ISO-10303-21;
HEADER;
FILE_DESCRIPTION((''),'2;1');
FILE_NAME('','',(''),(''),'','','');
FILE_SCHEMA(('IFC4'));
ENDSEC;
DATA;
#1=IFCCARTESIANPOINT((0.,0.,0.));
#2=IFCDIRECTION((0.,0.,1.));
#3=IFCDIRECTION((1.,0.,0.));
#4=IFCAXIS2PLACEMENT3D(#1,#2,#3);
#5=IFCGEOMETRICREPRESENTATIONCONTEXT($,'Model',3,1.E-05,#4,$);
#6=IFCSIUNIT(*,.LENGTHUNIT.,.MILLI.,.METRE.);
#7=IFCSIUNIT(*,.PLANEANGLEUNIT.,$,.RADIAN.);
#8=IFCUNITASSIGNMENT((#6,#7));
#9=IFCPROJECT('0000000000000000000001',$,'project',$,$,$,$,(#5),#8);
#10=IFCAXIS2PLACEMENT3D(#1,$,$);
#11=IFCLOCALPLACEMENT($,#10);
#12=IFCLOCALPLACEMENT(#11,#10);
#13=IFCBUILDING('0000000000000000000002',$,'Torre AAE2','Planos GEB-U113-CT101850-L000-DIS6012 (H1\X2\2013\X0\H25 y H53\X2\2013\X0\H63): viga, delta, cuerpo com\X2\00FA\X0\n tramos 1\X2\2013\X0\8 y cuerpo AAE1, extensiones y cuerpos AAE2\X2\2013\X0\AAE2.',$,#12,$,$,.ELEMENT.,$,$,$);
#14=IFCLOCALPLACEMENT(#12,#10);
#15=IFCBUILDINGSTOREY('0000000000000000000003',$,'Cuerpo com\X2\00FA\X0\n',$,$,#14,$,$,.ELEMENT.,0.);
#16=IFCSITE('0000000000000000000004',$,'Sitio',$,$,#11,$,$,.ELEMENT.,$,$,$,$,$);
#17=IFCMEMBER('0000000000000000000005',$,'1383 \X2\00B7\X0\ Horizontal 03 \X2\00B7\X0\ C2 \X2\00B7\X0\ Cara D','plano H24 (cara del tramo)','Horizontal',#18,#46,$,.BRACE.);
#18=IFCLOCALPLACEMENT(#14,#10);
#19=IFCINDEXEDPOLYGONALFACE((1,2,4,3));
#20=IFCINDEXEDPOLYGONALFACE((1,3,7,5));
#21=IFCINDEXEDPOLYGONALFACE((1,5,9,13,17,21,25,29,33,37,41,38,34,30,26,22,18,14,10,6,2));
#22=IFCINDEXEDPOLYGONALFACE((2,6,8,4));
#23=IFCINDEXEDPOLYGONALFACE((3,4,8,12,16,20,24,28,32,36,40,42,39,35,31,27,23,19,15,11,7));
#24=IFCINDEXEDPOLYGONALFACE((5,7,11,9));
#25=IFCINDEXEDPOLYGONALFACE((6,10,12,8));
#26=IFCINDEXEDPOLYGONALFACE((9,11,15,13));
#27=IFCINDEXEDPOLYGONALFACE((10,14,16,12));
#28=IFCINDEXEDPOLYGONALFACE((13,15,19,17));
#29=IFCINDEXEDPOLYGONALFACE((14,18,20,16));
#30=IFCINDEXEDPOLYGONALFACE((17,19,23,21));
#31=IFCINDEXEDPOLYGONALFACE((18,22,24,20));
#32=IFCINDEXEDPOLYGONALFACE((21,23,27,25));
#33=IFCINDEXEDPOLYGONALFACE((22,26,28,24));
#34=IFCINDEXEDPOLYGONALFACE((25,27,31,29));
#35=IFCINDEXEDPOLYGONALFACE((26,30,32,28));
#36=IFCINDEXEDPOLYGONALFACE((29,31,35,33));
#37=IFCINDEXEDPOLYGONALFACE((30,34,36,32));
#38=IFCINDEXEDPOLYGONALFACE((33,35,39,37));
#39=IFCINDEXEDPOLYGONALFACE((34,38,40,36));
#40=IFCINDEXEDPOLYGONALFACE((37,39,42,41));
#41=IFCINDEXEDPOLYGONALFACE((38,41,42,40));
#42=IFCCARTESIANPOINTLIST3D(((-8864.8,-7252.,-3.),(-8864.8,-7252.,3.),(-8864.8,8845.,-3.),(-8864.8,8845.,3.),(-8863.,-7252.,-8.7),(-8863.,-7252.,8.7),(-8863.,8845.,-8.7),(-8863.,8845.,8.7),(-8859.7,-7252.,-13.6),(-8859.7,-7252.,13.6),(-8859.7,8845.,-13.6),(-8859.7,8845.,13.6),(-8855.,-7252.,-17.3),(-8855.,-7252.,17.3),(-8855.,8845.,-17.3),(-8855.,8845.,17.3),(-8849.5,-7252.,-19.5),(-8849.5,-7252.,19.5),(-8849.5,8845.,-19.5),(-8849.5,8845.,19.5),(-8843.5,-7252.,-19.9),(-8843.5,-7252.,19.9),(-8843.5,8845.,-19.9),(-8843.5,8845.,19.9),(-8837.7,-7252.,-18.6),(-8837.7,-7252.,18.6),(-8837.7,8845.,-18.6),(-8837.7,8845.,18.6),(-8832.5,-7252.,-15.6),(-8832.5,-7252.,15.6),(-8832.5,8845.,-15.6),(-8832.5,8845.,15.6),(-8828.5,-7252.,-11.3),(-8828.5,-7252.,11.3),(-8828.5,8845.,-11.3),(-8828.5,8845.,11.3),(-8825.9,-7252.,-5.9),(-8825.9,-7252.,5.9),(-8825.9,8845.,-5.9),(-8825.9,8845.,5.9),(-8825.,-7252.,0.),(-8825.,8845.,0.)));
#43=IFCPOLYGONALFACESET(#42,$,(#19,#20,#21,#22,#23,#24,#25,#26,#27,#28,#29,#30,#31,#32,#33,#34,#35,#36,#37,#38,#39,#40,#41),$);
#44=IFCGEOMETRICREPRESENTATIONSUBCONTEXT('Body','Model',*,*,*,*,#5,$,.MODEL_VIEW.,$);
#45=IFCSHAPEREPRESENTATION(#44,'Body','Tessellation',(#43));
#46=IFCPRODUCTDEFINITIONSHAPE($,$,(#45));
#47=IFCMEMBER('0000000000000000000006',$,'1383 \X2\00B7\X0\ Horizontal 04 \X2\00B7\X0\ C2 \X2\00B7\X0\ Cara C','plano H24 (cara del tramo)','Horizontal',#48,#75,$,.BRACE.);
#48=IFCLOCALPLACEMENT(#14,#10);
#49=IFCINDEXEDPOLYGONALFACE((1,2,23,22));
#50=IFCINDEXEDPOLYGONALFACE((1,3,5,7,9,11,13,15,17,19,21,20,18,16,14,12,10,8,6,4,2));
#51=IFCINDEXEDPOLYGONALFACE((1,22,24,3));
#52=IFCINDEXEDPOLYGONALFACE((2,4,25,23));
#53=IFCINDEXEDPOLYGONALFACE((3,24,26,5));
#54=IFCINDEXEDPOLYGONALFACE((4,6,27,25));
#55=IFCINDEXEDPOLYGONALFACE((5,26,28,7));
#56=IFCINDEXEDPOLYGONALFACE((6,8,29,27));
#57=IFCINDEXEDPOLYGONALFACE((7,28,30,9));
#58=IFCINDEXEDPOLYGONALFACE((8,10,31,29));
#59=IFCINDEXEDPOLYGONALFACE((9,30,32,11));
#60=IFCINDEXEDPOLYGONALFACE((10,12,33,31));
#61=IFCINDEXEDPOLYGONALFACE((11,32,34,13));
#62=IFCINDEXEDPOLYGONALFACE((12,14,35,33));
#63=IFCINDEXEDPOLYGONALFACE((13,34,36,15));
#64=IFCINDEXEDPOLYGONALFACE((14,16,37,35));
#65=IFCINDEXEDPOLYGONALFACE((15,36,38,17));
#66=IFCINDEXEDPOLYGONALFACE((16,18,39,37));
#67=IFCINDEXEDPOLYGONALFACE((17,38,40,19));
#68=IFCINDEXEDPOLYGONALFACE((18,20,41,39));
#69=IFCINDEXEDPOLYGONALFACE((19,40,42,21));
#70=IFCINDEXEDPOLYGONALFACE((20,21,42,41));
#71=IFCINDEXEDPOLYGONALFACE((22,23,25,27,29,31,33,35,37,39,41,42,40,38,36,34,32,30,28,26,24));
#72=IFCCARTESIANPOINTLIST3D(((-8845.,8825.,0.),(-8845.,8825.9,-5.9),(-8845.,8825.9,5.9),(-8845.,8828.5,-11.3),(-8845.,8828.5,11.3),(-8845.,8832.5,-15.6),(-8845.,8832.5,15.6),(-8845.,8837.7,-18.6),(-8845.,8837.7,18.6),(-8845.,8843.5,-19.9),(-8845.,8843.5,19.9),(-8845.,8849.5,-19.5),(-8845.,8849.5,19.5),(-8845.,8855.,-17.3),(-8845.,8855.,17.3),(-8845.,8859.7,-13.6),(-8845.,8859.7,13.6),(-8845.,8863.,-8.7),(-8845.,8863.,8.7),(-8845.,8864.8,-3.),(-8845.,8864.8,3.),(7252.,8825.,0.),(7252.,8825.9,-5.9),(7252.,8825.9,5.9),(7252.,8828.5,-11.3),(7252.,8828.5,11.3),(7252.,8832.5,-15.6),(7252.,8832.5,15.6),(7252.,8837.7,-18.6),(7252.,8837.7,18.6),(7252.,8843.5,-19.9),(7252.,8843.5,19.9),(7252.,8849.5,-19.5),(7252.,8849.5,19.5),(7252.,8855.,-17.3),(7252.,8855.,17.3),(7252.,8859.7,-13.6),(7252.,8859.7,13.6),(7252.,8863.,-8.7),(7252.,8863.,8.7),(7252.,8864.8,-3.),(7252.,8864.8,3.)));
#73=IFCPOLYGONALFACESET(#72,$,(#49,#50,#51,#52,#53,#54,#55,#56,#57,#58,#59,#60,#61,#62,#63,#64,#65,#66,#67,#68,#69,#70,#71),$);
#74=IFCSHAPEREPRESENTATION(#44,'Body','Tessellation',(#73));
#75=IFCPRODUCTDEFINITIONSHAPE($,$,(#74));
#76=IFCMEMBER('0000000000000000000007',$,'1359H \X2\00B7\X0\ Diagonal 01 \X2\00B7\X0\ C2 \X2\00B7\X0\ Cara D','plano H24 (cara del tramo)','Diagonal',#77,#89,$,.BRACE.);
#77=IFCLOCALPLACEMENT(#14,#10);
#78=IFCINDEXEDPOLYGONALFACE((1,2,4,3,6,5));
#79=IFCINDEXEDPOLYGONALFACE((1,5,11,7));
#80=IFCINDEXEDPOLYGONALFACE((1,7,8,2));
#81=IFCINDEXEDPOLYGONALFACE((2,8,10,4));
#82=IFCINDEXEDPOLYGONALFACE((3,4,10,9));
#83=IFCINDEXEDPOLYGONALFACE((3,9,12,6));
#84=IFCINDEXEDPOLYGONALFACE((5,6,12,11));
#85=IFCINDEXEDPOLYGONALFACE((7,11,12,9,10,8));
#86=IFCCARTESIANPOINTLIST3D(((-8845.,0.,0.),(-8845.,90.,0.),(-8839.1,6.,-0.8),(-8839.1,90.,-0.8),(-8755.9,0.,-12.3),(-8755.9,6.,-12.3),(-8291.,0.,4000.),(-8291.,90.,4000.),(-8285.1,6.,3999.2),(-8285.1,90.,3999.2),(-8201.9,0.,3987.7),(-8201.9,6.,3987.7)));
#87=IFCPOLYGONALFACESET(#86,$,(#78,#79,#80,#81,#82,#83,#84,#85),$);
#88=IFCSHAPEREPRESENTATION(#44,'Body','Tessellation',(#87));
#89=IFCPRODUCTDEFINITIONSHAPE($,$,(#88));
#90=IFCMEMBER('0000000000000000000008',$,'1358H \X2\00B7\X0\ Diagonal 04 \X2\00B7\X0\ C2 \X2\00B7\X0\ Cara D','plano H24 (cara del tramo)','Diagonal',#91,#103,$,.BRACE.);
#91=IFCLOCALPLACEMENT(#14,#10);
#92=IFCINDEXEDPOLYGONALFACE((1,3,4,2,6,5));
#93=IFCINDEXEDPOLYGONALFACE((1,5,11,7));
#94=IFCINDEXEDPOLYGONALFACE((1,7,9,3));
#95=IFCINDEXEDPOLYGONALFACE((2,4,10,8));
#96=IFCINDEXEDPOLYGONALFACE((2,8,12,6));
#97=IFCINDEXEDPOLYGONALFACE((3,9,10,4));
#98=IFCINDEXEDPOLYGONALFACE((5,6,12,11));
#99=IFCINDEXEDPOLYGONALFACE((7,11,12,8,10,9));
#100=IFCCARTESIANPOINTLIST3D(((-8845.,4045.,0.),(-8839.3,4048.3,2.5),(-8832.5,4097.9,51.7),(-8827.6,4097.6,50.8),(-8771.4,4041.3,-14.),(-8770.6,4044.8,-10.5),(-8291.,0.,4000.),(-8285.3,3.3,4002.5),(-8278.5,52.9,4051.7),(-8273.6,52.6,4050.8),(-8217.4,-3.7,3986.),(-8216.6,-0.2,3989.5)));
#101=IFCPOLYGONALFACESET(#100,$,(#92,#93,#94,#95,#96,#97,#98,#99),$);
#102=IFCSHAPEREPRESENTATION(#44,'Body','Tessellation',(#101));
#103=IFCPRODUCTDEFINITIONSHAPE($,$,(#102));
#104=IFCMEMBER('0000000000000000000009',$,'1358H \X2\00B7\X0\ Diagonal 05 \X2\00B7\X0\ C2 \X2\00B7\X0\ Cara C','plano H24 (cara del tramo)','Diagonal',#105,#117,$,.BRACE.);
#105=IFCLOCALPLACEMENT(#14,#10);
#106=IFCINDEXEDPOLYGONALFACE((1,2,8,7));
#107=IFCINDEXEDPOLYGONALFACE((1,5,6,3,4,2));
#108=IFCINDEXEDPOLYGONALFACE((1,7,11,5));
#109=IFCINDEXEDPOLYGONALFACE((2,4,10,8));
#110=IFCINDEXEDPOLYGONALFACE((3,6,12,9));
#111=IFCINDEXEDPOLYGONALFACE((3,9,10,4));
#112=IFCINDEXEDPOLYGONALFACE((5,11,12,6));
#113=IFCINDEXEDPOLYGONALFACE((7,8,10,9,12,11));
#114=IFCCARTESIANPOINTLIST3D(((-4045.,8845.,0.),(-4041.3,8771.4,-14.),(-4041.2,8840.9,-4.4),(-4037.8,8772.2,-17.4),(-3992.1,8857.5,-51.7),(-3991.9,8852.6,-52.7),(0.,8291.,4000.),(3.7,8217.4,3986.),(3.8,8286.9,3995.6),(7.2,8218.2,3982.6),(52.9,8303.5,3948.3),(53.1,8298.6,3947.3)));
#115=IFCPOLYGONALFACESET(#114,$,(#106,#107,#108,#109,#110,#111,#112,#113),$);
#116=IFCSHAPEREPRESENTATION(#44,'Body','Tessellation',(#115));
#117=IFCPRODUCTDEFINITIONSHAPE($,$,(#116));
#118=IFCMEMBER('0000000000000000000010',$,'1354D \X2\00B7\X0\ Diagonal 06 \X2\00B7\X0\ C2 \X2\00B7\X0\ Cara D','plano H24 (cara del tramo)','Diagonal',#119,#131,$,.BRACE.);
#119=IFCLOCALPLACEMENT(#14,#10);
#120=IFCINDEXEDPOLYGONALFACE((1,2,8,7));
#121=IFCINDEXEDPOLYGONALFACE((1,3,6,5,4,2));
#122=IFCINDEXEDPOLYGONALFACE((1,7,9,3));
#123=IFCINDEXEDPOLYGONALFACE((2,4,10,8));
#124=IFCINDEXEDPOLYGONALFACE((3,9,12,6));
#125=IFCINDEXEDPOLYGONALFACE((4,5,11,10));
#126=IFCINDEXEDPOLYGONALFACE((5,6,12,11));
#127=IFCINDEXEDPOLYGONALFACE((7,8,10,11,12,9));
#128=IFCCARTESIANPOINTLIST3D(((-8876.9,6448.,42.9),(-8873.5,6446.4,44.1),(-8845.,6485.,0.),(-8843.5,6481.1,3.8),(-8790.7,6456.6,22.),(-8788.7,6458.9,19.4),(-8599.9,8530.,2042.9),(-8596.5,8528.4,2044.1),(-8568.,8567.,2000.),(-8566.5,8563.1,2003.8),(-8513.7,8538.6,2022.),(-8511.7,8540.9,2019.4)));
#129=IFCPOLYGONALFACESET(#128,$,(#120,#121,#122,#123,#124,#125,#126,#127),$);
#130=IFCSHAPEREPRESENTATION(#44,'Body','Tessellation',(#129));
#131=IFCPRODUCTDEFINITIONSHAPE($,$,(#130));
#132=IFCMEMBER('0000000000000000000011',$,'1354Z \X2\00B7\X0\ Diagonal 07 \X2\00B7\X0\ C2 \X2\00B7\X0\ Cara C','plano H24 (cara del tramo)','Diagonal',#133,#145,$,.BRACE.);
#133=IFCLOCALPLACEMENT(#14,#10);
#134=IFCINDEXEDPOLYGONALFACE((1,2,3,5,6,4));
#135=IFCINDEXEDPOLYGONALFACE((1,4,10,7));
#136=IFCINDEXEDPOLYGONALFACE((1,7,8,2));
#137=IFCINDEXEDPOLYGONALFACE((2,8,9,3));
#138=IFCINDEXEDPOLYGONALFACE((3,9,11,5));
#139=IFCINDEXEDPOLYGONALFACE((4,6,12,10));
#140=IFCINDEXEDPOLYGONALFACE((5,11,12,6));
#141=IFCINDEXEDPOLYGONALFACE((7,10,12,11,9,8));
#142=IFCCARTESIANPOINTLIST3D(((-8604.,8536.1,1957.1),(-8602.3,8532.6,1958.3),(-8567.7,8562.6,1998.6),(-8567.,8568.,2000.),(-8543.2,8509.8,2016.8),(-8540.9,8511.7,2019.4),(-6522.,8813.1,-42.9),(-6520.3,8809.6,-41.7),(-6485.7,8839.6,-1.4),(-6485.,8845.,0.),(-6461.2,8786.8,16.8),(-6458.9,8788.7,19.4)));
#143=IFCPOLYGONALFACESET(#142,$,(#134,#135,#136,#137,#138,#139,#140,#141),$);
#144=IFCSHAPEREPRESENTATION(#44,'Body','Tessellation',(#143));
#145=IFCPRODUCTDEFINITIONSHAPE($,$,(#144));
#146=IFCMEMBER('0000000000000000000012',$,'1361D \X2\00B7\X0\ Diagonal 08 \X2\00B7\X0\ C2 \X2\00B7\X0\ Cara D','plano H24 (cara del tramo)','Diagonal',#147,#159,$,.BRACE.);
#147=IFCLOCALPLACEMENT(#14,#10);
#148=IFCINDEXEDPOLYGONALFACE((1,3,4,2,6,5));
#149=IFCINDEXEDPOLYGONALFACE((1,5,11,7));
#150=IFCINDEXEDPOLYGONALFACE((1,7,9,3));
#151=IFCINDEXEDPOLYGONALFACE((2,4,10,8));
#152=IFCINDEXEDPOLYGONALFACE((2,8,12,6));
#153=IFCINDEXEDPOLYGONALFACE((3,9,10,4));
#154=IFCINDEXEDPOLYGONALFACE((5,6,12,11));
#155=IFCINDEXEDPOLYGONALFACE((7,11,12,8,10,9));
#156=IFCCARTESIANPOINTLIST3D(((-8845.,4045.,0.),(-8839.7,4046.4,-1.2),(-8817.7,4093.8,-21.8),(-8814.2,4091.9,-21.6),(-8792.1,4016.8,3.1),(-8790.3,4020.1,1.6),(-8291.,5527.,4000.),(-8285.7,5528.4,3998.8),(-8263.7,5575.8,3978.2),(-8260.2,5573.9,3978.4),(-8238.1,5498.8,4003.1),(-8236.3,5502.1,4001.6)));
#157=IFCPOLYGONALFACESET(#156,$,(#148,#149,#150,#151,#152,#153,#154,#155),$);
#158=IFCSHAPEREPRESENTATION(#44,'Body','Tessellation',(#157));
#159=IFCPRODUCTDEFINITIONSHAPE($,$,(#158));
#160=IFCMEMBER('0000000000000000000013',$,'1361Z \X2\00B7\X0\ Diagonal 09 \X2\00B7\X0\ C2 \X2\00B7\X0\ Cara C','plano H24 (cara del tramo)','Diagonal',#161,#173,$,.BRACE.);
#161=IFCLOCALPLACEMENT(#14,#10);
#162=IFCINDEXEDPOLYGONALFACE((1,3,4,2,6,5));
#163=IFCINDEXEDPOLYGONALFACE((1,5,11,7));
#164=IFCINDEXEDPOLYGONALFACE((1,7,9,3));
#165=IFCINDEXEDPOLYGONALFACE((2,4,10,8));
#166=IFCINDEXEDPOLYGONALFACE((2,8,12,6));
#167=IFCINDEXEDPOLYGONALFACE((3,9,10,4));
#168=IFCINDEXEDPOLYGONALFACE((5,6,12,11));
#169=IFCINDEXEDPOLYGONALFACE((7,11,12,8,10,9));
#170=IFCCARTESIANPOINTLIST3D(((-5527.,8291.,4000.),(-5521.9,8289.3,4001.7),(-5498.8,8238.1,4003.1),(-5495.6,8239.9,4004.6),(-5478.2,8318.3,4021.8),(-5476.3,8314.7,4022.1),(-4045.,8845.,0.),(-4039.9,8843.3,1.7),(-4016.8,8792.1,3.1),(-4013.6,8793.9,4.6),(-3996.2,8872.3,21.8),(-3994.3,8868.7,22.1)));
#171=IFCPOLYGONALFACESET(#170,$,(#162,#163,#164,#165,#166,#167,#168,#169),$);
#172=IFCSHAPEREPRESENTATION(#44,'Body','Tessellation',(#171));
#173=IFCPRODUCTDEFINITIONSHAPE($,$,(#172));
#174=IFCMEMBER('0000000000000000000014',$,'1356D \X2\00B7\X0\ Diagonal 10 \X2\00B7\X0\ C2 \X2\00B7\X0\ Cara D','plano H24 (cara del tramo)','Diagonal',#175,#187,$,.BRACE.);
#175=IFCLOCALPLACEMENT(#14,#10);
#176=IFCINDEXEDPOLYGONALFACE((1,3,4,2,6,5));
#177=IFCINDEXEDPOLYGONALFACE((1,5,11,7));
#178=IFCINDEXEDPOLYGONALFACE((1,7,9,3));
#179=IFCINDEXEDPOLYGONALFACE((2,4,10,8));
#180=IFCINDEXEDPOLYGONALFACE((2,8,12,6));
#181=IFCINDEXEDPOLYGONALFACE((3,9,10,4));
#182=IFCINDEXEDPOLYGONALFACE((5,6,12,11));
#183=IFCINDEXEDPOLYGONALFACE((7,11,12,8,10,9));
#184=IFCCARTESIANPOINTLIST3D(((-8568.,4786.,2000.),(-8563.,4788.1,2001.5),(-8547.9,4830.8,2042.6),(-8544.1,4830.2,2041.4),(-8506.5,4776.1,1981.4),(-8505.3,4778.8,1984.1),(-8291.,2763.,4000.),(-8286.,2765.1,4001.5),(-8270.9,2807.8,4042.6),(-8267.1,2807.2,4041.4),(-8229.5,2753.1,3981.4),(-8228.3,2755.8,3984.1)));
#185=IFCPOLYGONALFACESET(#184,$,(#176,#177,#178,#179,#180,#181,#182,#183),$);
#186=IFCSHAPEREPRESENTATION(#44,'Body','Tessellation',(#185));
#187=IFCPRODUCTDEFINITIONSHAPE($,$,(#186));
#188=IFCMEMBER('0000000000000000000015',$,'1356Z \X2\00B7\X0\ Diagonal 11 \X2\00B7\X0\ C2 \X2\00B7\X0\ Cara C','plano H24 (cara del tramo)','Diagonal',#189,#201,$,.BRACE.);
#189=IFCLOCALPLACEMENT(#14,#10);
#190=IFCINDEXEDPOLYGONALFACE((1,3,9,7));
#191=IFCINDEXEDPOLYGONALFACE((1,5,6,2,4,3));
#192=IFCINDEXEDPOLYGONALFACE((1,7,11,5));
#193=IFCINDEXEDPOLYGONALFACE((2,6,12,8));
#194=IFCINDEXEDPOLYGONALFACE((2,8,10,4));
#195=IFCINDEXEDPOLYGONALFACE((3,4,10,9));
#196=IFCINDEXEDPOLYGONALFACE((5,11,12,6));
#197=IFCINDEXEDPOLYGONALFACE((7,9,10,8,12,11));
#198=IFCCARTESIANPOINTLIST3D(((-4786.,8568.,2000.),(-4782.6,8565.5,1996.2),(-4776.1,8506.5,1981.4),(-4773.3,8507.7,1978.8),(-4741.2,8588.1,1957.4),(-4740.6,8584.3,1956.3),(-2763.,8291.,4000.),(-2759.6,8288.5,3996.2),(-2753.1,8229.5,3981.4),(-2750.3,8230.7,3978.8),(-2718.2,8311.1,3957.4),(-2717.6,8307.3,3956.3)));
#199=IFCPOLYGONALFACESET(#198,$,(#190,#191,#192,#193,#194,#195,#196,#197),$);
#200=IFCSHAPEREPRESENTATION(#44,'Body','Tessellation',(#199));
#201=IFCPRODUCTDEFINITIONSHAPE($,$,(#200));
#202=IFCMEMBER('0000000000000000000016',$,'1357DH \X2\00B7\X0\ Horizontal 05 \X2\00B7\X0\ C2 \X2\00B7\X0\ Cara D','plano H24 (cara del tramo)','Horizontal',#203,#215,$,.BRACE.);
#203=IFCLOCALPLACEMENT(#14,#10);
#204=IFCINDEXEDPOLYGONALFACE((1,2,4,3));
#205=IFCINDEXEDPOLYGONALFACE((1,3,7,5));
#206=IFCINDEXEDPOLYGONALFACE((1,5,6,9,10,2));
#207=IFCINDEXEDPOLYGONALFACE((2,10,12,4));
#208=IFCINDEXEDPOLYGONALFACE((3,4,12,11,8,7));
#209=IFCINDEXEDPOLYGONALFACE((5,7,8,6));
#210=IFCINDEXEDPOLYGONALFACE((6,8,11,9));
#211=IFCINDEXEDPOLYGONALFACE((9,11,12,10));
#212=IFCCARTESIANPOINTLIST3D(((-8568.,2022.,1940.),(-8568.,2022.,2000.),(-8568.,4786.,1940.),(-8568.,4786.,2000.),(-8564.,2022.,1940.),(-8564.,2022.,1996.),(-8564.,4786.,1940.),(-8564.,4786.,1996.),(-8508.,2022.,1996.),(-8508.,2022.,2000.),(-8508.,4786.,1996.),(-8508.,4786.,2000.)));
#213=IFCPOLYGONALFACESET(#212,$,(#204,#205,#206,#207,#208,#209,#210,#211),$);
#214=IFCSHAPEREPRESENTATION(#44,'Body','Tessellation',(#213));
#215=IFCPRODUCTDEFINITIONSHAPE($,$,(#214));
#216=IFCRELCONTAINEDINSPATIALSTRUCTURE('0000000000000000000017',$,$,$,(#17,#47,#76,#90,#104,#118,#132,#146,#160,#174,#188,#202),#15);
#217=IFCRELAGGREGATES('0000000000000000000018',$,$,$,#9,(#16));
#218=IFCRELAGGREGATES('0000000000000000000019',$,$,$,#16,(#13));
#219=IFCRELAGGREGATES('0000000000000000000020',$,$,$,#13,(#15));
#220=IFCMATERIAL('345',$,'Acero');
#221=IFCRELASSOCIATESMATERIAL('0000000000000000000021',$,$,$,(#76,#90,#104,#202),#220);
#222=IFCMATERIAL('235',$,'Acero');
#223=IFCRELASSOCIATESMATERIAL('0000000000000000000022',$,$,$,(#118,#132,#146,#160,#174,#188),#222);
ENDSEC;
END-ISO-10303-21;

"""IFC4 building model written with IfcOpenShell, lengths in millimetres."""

from ifc_helpers import new_model, si_unit, frame, frame_2d, origin, origin_with_axes, place, context, subcontext, project, spatial, circle, l_section, extrude, material, element, save


model = new_model("IFC4")

# Units and contexts
model_context = context("Model", 3, precision=1e-05, world=origin_with_axes())
body_context = subcontext(model_context, "Body", "Model", "MODEL_VIEW")
ifc_project = project(units=[si_unit("LENGTHUNIT", "METRE", prefix="MILLI"), si_unit("PLANEANGLEUNIT", "RADIAN")], contexts=[model_context])

# Site, building, storey
site_placement = place(None, origin())
site = spatial("IfcSite", under=ifc_project, at=site_placement, Name="Sitio", CompositionType="ELEMENT")
building_placement = place(site_placement, origin())
building = spatial("IfcBuilding", under=site, at=building_placement, Name="Torre AAE2", Description="Planos GEB-U113-CT101850-L000-DIS6012 (H1–H25 y H53–H63): viga, delta, cuerpo común tramos 1–8 y cuerpo AAE1, extensiones y cuerpos AAE2–AAE2.", CompositionType="ELEMENT")
storey_placement = place(building_placement, origin())
storey = spatial("IfcBuildingStorey", under=building, at=storey_placement, Name="Cuerpo común", CompositionType="ELEMENT", Elevation=0.0)

# Members
for number, where, z_axis, x_axis, name in (
    (1, (-8845.0, 8845.0, 0.0), (0.0, -1.0, 0.0), (1.0, 0.0, 0.0), "1383 · Horizontal 03 · C2 · Cara D"),
    (2, (-8845.0, 8845.0, 0.0), (1.0, 0.0, 0.0), (0.0, -1.0, 0.0), "1383 · Horizontal 04 · C2 · Cara C"),
):
    element("IfcMember", number, at=place(storey_placement, frame(where, z_axis=z_axis, x_axis=x_axis)), inside=storey, Name=name, Description="plano H24 (cara del tramo)", ObjectType="Horizontal", PredefinedType="BRACE", context=body_context, shape_type="SweptSolid", body=[
        extrude(circle(Radius=20.0), None, (0.0, 0.0, 1.0), 16097.0),
    ])
ifc_material_1 = material(Name="345", Category="Acero")
member_1_placement = place(storey_placement, frame((-8845.0, 0.0, 0.0), z_axis=(0.13719, 0.0, 0.990545), x_axis=(0.990545, 0.0, -0.13719)))
element("IfcMember", 3, at=member_1_placement, inside=storey, material=ifc_material_1, Name="1359H · Diagonal 01 · C2 · Cara D", Description="plano H24 (cara del tramo)", ObjectType="Diagonal", PredefinedType="BRACE", context=body_context, shape_type="SweptSolid", body=[
    extrude(l_section(Depth=90.0, Width=90.0, Thickness=6.0, at=frame_2d((45.0, 45.0))), None, (0.0, 0.0, 1.0), 4038.2),
])
for number, where, z_axis, x_axis, name in (
    (4, (-8845.0, 4045.0, 0.0), (0.096926, -0.707703, 0.69983), (0.981289, -0.04958, -0.186046), "1358H · Diagonal 04 · C2 · Cara D"),
    (5, (-4045.0, 8845.0, 0.0), (0.707703, -0.096926, 0.69983), (0.04958, -0.981289, -0.186046), "1358H · Diagonal 05 · C2 · Cara C"),
):
    element("IfcMember", number, at=place(storey_placement, frame(where, z_axis=z_axis, x_axis=x_axis)), inside=storey, material=ifc_material_1, Name=name, Description="plano H24 (cara del tramo)", ObjectType="Diagonal", PredefinedType="BRACE", context=body_context, shape_type="SweptSolid", body=[
        extrude(l_section(Depth=75.0, Width=75.0, Thickness=5.0, at=frame_2d((37.5, 37.5))), None, (0.0, 0.0, 1.0), 5715.7),
    ])
ifc_material_2 = material(Name="235", Category="Acero")
for number, where, z_axis, x_axis, name in (
    (6, (-8568.0, 8567.0, 2000.0), (-0.095509, -0.717869, -0.689596), (0.865687, -0.401881, 0.29846), "1354D · Diagonal 06 · C2 · Cara D"),
    (7, (-8567.0, 8568.0, 2000.0), (0.717869, 0.095509, -0.689596), (0.401881, -0.865687, 0.29846), "1354Z · Diagonal 07 · C2 · Cara C"),
):
    element("IfcMember", number, at=place(storey_placement, frame(where, z_axis=z_axis, x_axis=x_axis)), inside=storey, material=ifc_material_2, Name=name, Description="plano H24 (cara del tramo)", ObjectType="Diagonal", PredefinedType="BRACE", context=body_context, shape_type="SweptSolid", body=[
        extrude(l_section(Depth=65.0, Width=65.0, Thickness=4.0, at=frame_2d((32.5, 32.5))), None, (0.0, 0.0, 1.0), 2900.3),
    ])
for number, where, z_axis, x_axis, name in (
    (8, (-8845.0, 4045.0, 0.0), (0.128791, 0.344528, 0.9299), (0.88155, -0.469244, 0.05176), "1361D · Diagonal 08 · C2 · Cara D"),
    (9, (-4045.0, 8845.0, 0.0), (-0.344528, -0.128791, 0.9299), (0.469244, -0.88155, 0.05176), "1361Z · Diagonal 09 · C2 · Cara C"),
):
    element("IfcMember", number, at=place(storey_placement, frame(where, z_axis=z_axis, x_axis=x_axis)), inside=storey, material=ifc_material_2, Name=name, Description="plano H24 (cara del tramo)", ObjectType="Diagonal", PredefinedType="BRACE", context=body_context, shape_type="SweptSolid", body=[
        extrude(l_section(Depth=60.0, Width=60.0, Thickness=4.0, at=frame_2d((30.0, 30.0))), None, (0.0, 0.0, 1.0), 4301.5),
    ])
for number, where, z_axis, x_axis, name in (
    (10, (-8568.0, 4786.0, 2000.0), (0.096914, -0.70779, 0.699743), (0.946162, -0.152643, -0.285442), "1356D · Diagonal 10 · C2 · Cara D"),
    (11, (-4786.0, 8568.0, 2000.0), (0.70779, -0.096914, 0.699743), (0.152643, -0.946162, -0.285442), "1356Z · Diagonal 11 · C2 · Cara C"),
):
    element("IfcMember", number, at=place(storey_placement, frame(where, z_axis=z_axis, x_axis=x_axis)), inside=storey, material=ifc_material_2, Name=name, Description="plano H24 (cara del tramo)", ObjectType="Diagonal", PredefinedType="BRACE", context=body_context, shape_type="SweptSolid", body=[
        extrude(l_section(Depth=65.0, Width=65.0, Thickness=4.0, at=frame_2d((32.5, 32.5))), None, (0.0, 0.0, 1.0), 2858.2),
    ])
for number, where, z_axis, x_axis, name in (
    (12, (-8568.0, 2022.0, 2000.0), (0.0, 1.0, 0.0), (1.0, 0.0, 0.0), "1357DH · Horizontal 05 · C2 · Cara D"),
):
    element("IfcMember", number, at=place(storey_placement, frame(where, z_axis=z_axis, x_axis=x_axis)), inside=storey, material=ifc_material_1, Name=name, Description="plano H24 (cara del tramo)", ObjectType="Horizontal", PredefinedType="BRACE", context=body_context, shape_type="SweptSolid", body=[
        extrude(l_section(Depth=60.0, Width=60.0, Thickness=4.0, at=frame_2d((30.0, 30.0))), None, (0.0, 0.0, 1.0), 2764.0),
    ])

save(model, "model.ifc")
